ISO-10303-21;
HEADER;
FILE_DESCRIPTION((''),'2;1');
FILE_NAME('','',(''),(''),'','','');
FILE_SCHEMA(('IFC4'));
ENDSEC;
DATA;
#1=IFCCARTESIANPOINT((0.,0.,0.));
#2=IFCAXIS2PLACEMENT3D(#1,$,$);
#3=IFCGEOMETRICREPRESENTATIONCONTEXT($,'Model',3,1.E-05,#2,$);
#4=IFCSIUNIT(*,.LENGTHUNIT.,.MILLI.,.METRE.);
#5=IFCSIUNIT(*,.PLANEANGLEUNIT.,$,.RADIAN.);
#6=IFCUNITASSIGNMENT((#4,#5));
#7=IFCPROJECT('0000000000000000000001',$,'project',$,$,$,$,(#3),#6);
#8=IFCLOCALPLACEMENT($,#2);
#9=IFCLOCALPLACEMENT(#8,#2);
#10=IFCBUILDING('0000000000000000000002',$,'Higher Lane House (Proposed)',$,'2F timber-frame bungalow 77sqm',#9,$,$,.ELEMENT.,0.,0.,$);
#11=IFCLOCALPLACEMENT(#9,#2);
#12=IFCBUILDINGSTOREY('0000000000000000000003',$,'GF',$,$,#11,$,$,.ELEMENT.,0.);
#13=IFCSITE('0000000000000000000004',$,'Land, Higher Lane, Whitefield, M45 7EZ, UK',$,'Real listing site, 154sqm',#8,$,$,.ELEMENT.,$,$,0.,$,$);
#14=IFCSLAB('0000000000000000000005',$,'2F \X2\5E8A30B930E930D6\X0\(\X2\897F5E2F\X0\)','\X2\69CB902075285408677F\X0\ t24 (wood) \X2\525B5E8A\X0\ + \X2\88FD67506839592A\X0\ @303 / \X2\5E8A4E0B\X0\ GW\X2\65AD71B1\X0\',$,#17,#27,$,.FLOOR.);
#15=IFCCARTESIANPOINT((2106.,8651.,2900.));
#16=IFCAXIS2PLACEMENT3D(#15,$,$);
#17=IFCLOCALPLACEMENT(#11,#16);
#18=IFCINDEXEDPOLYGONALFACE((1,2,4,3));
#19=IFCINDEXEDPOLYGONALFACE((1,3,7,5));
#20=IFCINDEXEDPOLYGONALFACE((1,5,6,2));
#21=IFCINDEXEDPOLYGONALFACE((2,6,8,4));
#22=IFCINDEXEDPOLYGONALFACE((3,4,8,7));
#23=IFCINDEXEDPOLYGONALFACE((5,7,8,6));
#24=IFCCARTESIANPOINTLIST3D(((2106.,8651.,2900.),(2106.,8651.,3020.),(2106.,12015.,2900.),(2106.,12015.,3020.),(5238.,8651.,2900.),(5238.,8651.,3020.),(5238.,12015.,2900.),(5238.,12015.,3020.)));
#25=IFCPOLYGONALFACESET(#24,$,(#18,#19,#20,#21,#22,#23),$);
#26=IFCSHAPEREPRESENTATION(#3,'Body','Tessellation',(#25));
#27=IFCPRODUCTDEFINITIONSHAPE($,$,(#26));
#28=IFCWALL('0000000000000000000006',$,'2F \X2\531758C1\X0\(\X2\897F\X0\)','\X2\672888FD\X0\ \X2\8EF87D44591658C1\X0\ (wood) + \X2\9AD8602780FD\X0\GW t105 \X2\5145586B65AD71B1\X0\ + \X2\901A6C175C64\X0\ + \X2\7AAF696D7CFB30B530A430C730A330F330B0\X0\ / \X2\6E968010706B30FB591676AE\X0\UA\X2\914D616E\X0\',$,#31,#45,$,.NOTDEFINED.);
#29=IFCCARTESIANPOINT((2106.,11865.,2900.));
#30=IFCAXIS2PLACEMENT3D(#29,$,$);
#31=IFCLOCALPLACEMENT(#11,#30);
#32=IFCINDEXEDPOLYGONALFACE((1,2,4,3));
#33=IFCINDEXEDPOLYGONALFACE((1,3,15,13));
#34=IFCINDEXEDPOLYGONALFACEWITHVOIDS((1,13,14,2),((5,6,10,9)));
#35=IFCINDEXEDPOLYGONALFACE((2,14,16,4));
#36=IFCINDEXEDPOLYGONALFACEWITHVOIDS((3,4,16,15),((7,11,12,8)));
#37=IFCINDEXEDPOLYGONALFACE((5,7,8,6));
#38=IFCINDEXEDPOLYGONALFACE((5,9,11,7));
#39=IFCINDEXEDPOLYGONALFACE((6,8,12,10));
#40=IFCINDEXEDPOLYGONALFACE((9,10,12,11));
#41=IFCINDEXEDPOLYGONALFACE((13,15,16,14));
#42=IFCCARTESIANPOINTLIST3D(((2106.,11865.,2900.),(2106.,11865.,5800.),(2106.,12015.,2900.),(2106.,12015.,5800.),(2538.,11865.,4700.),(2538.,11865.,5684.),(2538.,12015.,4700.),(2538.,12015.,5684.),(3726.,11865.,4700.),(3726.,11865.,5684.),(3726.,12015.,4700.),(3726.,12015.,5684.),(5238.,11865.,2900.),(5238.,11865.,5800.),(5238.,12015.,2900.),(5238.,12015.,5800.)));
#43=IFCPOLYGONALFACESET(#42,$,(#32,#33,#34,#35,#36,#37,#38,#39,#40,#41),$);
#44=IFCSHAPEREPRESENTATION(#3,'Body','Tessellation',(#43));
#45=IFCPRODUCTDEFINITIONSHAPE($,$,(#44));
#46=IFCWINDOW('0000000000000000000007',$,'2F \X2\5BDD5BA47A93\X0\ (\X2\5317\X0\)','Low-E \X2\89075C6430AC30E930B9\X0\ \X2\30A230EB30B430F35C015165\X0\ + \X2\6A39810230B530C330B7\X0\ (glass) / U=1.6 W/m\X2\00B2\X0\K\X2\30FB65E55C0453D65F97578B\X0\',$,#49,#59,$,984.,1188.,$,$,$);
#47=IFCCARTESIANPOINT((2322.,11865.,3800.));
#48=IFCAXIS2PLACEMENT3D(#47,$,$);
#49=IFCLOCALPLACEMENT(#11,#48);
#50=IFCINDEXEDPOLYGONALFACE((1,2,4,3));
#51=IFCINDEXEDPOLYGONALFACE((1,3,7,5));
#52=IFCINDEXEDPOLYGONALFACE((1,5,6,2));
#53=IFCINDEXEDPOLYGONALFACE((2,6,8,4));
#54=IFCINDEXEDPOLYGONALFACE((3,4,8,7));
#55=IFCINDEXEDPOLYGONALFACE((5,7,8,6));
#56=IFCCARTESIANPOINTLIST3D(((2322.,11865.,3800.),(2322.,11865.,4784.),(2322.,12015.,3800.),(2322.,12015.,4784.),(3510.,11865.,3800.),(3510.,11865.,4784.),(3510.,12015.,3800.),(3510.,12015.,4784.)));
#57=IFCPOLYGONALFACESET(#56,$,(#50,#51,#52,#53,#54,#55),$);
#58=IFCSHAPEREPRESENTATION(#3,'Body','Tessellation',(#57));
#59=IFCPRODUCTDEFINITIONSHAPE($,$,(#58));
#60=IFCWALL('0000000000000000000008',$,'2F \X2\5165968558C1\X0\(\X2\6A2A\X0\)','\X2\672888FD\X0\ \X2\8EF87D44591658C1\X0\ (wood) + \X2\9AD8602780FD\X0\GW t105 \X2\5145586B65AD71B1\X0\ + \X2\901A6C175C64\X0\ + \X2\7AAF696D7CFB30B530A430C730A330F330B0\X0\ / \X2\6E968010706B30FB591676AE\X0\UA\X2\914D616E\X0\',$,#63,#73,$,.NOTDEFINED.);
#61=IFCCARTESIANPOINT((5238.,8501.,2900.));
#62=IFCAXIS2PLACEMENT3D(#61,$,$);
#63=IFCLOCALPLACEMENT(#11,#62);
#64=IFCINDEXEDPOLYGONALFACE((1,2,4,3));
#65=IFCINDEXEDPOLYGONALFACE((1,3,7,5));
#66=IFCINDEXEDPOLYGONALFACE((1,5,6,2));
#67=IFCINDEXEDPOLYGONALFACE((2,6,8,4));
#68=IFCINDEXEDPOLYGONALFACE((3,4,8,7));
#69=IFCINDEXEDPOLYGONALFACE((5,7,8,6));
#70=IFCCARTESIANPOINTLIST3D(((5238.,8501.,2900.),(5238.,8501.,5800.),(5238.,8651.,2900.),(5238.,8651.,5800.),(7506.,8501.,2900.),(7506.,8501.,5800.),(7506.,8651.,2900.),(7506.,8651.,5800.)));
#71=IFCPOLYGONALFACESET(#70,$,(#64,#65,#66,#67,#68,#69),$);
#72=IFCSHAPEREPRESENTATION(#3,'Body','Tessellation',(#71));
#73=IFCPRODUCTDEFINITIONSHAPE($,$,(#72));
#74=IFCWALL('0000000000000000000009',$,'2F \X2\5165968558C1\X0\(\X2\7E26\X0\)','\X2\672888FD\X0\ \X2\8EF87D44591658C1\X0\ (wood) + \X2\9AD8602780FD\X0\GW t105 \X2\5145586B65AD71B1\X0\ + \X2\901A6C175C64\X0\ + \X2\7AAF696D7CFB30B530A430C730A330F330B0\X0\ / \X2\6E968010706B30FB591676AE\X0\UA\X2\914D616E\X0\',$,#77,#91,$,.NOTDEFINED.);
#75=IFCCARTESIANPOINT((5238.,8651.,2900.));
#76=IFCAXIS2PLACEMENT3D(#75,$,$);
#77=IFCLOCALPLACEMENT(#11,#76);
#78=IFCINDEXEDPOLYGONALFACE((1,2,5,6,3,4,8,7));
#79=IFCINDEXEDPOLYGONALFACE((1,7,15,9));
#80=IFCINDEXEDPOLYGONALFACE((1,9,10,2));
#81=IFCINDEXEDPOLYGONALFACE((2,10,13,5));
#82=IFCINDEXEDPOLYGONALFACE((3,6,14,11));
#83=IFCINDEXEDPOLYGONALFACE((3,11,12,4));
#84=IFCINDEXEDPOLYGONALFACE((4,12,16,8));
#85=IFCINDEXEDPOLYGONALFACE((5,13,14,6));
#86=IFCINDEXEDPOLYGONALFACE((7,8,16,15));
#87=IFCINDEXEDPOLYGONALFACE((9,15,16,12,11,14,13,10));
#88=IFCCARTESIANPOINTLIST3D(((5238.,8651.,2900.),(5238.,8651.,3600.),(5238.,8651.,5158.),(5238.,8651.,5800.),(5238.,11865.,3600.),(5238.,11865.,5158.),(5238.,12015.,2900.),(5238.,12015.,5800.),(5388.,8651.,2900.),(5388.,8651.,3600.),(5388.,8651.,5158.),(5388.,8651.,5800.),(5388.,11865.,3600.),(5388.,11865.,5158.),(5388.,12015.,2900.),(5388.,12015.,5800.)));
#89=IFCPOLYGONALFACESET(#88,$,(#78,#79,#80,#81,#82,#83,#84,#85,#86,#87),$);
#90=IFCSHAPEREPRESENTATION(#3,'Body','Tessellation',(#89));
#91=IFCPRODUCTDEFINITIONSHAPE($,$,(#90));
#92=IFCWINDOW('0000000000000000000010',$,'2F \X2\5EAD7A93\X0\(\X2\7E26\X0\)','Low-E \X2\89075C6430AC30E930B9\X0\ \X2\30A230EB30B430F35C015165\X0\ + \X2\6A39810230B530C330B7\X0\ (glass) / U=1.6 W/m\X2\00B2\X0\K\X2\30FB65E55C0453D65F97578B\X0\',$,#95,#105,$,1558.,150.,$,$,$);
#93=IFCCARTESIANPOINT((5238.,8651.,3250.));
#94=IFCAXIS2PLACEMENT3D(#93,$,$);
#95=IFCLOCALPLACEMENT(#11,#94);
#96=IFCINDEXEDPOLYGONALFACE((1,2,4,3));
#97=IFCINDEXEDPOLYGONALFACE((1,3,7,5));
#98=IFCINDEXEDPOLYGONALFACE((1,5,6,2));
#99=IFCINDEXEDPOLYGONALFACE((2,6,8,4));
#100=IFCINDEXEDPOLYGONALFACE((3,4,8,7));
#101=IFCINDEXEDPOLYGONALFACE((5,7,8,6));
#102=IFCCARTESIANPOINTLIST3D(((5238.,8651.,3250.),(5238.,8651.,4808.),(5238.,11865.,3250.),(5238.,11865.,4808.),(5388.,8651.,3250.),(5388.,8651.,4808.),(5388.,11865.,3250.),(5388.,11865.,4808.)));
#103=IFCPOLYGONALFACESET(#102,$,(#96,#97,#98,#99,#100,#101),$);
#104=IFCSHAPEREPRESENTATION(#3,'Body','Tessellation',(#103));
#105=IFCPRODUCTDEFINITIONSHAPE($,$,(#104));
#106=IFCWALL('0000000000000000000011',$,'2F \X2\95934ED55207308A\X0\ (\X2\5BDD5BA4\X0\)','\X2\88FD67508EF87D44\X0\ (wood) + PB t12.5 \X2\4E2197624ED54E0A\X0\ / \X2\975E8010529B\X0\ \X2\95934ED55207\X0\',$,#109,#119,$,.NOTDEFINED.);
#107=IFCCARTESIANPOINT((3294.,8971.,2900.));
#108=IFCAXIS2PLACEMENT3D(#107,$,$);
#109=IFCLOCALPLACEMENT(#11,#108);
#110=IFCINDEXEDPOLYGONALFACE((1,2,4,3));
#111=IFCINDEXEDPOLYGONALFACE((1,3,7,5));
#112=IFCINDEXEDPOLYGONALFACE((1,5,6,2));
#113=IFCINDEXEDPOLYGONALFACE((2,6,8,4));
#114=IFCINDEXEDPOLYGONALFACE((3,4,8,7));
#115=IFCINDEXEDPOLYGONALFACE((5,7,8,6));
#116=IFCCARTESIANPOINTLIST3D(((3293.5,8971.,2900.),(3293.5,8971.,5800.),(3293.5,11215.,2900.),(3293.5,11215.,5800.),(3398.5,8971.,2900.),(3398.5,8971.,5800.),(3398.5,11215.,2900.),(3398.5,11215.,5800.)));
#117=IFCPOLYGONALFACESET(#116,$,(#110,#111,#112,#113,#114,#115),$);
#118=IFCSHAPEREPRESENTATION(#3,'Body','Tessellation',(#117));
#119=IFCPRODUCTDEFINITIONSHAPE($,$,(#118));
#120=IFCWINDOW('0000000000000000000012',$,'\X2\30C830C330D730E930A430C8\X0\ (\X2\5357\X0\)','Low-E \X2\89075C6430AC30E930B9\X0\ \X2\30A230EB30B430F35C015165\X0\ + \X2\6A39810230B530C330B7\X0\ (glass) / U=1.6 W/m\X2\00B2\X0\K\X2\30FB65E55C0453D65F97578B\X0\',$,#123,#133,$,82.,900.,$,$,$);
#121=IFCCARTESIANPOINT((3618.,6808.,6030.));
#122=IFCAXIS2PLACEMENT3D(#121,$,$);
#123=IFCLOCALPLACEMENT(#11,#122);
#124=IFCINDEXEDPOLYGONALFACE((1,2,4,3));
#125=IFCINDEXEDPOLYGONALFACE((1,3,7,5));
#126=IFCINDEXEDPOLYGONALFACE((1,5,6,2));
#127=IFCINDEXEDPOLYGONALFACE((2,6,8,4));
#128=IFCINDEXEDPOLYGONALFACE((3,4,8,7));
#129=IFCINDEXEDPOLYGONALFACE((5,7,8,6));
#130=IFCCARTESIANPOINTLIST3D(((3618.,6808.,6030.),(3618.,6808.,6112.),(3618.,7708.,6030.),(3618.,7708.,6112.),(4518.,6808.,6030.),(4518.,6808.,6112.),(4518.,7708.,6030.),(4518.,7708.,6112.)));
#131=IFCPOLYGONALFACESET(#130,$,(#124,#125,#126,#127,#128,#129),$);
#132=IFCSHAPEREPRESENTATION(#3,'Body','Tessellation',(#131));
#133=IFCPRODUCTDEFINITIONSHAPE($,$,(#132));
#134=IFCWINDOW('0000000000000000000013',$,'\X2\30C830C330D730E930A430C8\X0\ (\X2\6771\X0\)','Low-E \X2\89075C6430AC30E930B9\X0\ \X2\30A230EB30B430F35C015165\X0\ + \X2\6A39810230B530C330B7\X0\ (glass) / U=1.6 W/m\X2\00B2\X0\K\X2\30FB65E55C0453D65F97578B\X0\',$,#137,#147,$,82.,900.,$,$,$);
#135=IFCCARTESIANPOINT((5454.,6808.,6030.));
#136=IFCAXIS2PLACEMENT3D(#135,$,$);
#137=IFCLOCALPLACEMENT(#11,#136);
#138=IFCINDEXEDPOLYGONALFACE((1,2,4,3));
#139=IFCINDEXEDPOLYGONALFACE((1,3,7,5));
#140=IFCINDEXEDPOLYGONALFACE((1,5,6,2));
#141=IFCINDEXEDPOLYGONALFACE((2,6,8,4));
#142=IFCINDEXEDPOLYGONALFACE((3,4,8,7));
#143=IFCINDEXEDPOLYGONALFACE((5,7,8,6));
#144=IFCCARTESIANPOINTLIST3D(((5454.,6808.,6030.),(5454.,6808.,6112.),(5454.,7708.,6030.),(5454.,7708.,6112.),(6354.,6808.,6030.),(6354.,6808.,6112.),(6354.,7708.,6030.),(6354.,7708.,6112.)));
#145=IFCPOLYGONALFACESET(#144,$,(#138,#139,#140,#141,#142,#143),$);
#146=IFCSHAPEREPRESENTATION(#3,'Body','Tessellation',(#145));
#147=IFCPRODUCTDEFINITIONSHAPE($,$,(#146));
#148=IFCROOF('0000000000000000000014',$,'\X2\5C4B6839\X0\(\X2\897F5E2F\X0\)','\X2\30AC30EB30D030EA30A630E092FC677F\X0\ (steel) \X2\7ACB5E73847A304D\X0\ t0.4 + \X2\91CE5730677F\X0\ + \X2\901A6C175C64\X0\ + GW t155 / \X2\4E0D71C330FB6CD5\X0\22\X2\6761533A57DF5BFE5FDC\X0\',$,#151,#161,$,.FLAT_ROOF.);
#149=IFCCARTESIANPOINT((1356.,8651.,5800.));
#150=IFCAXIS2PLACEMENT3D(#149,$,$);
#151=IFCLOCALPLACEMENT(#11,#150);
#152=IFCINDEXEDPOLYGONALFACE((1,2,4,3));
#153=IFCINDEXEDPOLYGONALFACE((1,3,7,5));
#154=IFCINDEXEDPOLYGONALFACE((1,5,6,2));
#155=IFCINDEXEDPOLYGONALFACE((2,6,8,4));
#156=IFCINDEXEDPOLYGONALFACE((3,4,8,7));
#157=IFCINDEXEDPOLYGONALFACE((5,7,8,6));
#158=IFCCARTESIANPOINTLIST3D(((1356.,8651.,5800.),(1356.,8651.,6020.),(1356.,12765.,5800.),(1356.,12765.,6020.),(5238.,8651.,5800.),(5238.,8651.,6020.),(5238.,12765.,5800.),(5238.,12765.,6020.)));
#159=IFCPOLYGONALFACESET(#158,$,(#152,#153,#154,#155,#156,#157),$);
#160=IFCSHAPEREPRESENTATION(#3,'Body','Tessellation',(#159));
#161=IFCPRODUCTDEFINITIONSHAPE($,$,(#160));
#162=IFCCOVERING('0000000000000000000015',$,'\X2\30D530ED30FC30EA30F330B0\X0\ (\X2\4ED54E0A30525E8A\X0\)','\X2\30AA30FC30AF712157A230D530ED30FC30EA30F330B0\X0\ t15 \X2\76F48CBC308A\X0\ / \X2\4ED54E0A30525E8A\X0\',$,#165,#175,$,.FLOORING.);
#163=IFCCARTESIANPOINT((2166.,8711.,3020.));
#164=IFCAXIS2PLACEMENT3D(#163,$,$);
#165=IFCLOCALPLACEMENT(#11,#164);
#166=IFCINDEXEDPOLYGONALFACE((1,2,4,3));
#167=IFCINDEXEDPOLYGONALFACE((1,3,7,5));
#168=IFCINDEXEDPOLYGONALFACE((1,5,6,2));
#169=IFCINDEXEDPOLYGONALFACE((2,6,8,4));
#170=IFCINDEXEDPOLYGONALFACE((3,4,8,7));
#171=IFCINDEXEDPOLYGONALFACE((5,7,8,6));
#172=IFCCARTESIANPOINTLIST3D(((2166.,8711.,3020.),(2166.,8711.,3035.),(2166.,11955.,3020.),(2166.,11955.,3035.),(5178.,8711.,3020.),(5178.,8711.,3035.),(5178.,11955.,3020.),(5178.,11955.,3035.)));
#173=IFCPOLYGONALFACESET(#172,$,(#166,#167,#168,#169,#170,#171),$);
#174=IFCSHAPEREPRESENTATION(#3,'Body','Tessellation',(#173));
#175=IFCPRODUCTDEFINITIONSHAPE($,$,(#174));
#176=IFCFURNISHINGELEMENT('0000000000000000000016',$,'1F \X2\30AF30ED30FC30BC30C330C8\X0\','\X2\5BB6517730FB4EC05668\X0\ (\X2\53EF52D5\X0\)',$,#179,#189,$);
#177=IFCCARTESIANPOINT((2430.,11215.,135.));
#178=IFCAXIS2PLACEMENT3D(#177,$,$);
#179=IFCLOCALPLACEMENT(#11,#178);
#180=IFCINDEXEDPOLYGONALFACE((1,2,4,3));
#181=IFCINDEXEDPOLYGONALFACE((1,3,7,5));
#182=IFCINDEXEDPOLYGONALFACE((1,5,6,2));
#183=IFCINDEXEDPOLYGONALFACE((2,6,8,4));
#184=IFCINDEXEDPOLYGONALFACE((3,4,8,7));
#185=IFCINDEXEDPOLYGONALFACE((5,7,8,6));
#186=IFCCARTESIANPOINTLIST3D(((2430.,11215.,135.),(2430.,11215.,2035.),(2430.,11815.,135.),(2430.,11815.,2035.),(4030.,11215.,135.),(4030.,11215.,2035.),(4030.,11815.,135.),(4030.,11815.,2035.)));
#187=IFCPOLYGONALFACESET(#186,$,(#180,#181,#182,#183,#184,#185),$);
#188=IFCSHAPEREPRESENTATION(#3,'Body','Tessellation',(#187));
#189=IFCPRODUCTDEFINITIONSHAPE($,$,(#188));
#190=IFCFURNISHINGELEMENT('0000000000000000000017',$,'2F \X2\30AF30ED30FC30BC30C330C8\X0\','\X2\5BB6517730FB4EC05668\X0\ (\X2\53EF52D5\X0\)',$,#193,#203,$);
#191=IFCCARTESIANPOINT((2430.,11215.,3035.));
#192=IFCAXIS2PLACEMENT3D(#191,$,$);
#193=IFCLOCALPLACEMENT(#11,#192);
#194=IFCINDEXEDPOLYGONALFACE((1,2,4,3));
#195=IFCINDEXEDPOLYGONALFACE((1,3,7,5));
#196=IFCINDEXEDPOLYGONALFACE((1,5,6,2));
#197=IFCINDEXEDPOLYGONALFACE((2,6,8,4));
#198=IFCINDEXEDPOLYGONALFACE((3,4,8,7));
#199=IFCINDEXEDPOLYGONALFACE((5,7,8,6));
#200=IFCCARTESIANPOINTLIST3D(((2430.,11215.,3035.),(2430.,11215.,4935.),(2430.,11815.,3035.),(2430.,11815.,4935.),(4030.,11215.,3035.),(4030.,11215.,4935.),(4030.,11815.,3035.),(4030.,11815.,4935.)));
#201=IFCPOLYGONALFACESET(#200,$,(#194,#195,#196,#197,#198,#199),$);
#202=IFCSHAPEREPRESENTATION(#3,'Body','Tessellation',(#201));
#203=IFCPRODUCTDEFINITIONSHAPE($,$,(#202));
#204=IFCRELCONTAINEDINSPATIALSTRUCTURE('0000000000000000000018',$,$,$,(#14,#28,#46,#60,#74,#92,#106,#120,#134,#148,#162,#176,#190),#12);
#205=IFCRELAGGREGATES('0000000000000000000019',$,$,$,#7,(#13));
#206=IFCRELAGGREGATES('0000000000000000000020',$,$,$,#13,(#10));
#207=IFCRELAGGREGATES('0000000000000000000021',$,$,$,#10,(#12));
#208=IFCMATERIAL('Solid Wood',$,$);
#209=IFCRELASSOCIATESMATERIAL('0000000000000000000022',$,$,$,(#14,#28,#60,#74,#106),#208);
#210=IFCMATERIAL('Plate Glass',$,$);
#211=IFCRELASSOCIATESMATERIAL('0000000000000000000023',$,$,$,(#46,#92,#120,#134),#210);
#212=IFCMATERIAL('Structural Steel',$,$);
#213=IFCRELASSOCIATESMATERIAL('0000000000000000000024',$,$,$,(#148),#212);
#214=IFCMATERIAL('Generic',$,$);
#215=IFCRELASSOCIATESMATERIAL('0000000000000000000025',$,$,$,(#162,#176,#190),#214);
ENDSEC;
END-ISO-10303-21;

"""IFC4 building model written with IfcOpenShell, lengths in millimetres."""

from ifc_helpers import new_model, si_unit, frame, frame_2d, origin, place, context, project, spatial, rectangle, extrude, material, element, fill, save


model = new_model("IFC4")

# Units and contexts
model_context = context("Model", 3, precision=1e-05, world=origin())
ifc_project = project(units=[si_unit("LENGTHUNIT", "METRE", prefix="MILLI"), si_unit("PLANEANGLEUNIT", "RADIAN")], contexts=[model_context])

# Site, building, storey
site_placement = place(None, origin())
site = spatial("IfcSite", under=ifc_project, at=site_placement, Name="Land, Higher Lane, Whitefield, M45 7EZ, UK", ObjectType="Real listing site, 154sqm", CompositionType="ELEMENT", RefElevation=0.0)
building_placement = place(site_placement, origin())
building = spatial("IfcBuilding", under=site, at=building_placement, Name="Higher Lane House (Proposed)", ObjectType="2F timber-frame bungalow 77sqm", CompositionType="ELEMENT", ElevationOfRefHeight=0.0, ElevationOfTerrain=0.0)
storey_placement = place(building_placement, origin())
storey = spatial("IfcBuildingStorey", under=building, at=storey_placement, Name="GF", CompositionType="ELEMENT", Elevation=0.0)

# Slab
ifc_material_1 = material(Name="Solid Wood")
slab_placement = place(storey_placement, frame((2106.0, 8651.0, 2900.0)))
element("IfcSlab", 1, at=slab_placement, inside=storey, material=ifc_material_1, Name="2F 床スラブ(西帯)", Description="構造用合板 t24 (wood) 剛床 + 製材根太 @303 / 床下 GW断熱", PredefinedType="FLOOR", context=model_context, shape_type="SweptSolid", body=[
    extrude(rectangle(XDim=3132.0, YDim=3364.0, at=frame_2d((1566.0, 1682.0))), frame((2106.0, 8651.0, 2900.0)), (0.0, 0.0, 1.0), 120.0),
])

# Wall, opening, window
wall_1_placement = place(storey_placement, frame((2106.0, 11865.0, 2900.0)))
wall_1 = element("IfcWall", 2, at=wall_1_placement, inside=storey, material=ifc_material_1, Name="2F 北壁(西)", Description="木製 軸組外壁 (wood) + 高性能GW t105 充填断熱 + 通気層 + 窯業系サイディング / 準耐火・外皮UA配慮", PredefinedType="NOTDEFINED", context=model_context, shape_type="SweptSolid", body=[
    extrude(rectangle(XDim=3132.0, YDim=150.0, at=frame_2d((1566.0, 75.0))), frame((2106.0, 11865.0, 2900.0)), (0.0, 0.0, 1.0), 2900.0),
])
opening_1_placement = place(storey_placement, frame((2322.0, 11865.0, 3800.0)))
opening_1 = element("IfcOpeningElement", 3, at=opening_1_placement, cuts=wall_1, PredefinedType="NOTDEFINED", context=model_context, shape_type="SweptSolid", body=[
    extrude(rectangle(XDim=1188.0, YDim=150.0, at=frame_2d((594.0, 75.0))), frame((2322.0, 11865.0, 3800.0)), (0.0, 0.0, 1.0), 984.0),
])
ifc_material_2 = material(Name="Plate Glass")
window_1_placement = place(storey_placement, frame((2322.0, 11865.0, 3800.0)))
window_1 = element("IfcWindow", 4, at=window_1_placement, inside=storey, material=ifc_material_2, Name="2F 寝室窓 (北)", Description="Low-E 複層ガラス アルゴン封入 + 樹脂サッシ (glass) / U=1.6 W/m²K・日射取得型", OverallHeight=984.0, OverallWidth=1188.0, context=model_context, shape_type="SweptSolid", body=[
    extrude(rectangle(XDim=1188.0, YDim=150.0, at=frame_2d((594.0, 75.0))), frame((2322.0, 11865.0, 3800.0)), (0.0, 0.0, 1.0), 984.0),
])
fill(opening_1, window_1)

# Wall
wall_2_placement = place(storey_placement, frame((5238.0, 8501.0, 2900.0)))
element("IfcWall", 5, at=wall_2_placement, inside=storey, material=ifc_material_1, Name="2F 入隅壁(横)", Description="木製 軸組外壁 (wood) + 高性能GW t105 充填断熱 + 通気層 + 窯業系サイディング / 準耐火・外皮UA配慮", PredefinedType="NOTDEFINED", context=model_context, shape_type="SweptSolid", body=[
    extrude(rectangle(XDim=2268.0, YDim=150.0, at=frame_2d((1134.0, 75.0))), frame((5238.0, 8501.0, 2900.0)), (0.0, 0.0, 1.0), 2900.0),
])

# Wall, opening, window
wall_3_placement = place(storey_placement, frame((5238.0, 8651.0, 2900.0)))
wall_3 = element("IfcWall", 6, at=wall_3_placement, inside=storey, material=ifc_material_1, Name="2F 入隅壁(縦)", Description="木製 軸組外壁 (wood) + 高性能GW t105 充填断熱 + 通気層 + 窯業系サイディング / 準耐火・外皮UA配慮", PredefinedType="NOTDEFINED", context=model_context, shape_type="SweptSolid", body=[
    extrude(rectangle(XDim=150.0, YDim=3364.0, at=frame_2d((75.0, 1682.0))), frame((5238.0, 8651.0, 2900.0)), (0.0, 0.0, 1.0), 2900.0),
])
opening_2_placement = place(storey_placement, frame((5238.0, 8651.0, 3250.0)))
opening_2 = element("IfcOpeningElement", 7, at=opening_2_placement, cuts=wall_3, PredefinedType="NOTDEFINED", context=model_context, shape_type="SweptSolid", body=[
    extrude(rectangle(XDim=150.0, YDim=3214.0, at=frame_2d((75.0, 1607.0))), frame((5238.0, 8651.0, 3250.0)), (0.0, 0.0, 1.0), 1558.0),
])
window_2_placement = place(storey_placement, frame((5238.0, 8651.0, 3250.0)))
window_2 = element("IfcWindow", 8, at=window_2_placement, inside=storey, material=ifc_material_2, Name="2F 庭窓(縦)", Description="Low-E 複層ガラス アルゴン封入 + 樹脂サッシ (glass) / U=1.6 W/m²K・日射取得型", OverallHeight=1558.0, OverallWidth=150.0, context=model_context, shape_type="SweptSolid", body=[
    extrude(rectangle(XDim=150.0, YDim=3214.0, at=frame_2d((75.0, 1607.0))), frame((5238.0, 8651.0, 3250.0)), (0.0, 0.0, 1.0), 1558.0),
])
fill(opening_2, window_2)

# Wall
wall_4_placement = place(storey_placement, frame((3294.0, 8971.0, 2900.0)))
element("IfcWall", 9, at=wall_4_placement, inside=storey, material=ifc_material_1, Name="2F 間仕切り (寝室)", Description="製材軸組 (wood) + PB t12.5 両面仕上 / 非耐力 間仕切", PredefinedType="NOTDEFINED", context=model_context, shape_type="SweptSolid", body=[
    extrude(rectangle(XDim=105.0, YDim=2244.0, at=frame_2d((52.0, 1122.0))), frame((3294.0, 8971.0, 2900.0)), (0.0, 0.0, 1.0), 2900.0),
])

# Windows
window_3_placement = place(storey_placement, frame((3618.0, 6808.0, 6030.0)))
element("IfcWindow", 10, at=window_3_placement, inside=storey, material=ifc_material_2, Name="トップライト (南)", Description="Low-E 複層ガラス アルゴン封入 + 樹脂サッシ (glass) / U=1.6 W/m²K・日射取得型", OverallHeight=82.0, OverallWidth=900.0, context=model_context, shape_type="SweptSolid", body=[
    extrude(rectangle(XDim=900.0, YDim=900.0, at=frame_2d((450.0, 450.0))), frame((3618.0, 6808.0, 6030.0)), (0.0, 0.0, 1.0), 82.0),
])
window_4_placement = place(storey_placement, frame((5454.0, 6808.0, 6030.0)))
element("IfcWindow", 11, at=window_4_placement, inside=storey, material=ifc_material_2, Name="トップライト (東)", Description="Low-E 複層ガラス アルゴン封入 + 樹脂サッシ (glass) / U=1.6 W/m²K・日射取得型", OverallHeight=82.0, OverallWidth=900.0, context=model_context, shape_type="SweptSolid", body=[
    extrude(rectangle(XDim=900.0, YDim=900.0, at=frame_2d((450.0, 450.0))), frame((5454.0, 6808.0, 6030.0)), (0.0, 0.0, 1.0), 82.0),
])

# Roof
ifc_material_3 = material(Name="Structural Steel")
for number, where, name in (
    (12, (1356.0, 8651.0, 5800.0), "屋根(西帯)"),
):
    element("IfcRoof", number, at=place(storey_placement, frame(where)), inside=storey, material=ifc_material_3, Name=name, Description="ガルバリウム鋼板 (steel) 立平葺き t0.4 + 野地板 + 通気層 + GW t155 / 不燃・法22条区域対応", PredefinedType="FLAT_ROOF", context=model_context, shape_type="SweptSolid", body=[
        extrude(rectangle(XDim=3882.0, YDim=4114.0, at=frame_2d((1941.0, 2057.0))), frame((1356.0, 8651.0, 5800.0)), (0.0, 0.0, 1.0), 220.0),
    ])

# Covering
ifc_material_4 = material(Name="Generic")
covering_placement = place(storey_placement, frame((2166.0, 8711.0, 3020.0)))
element("IfcCovering", 13, at=covering_placement, inside=storey, material=ifc_material_4, Name="フローリング (仕上げ床)", Description="オーク無垢フローリング t15 直貼り / 仕上げ床", PredefinedType="FLOORING", context=model_context, shape_type="SweptSolid", body=[
    extrude(rectangle(XDim=3012.0, YDim=3244.0, at=frame_2d((1506.0, 1622.0))), frame((2166.0, 8711.0, 3020.0)), (0.0, 0.0, 1.0), 15.0),
])

# Furnishing elements
furnishing_1_placement = place(storey_placement, frame((2430.0, 11215.0, 135.0)))
element("IfcFurnishingElement", 14, at=furnishing_1_placement, inside=storey, material=ifc_material_4, Name="1F クローゼット", Description="家具・什器 (可動)", context=model_context, shape_type="SweptSolid", body=[
    extrude(rectangle(XDim=1600.0, YDim=600.0, at=frame_2d((800.0, 300.0))), frame((2430.0, 11215.0, 135.0)), (0.0, 0.0, 1.0), 1900.0),
])
furnishing_2_placement = place(storey_placement, frame((2430.0, 11215.0, 3035.0)))
element("IfcFurnishingElement", 15, at=furnishing_2_placement, inside=storey, material=ifc_material_4, Name="2F クローゼット", Description="家具・什器 (可動)", context=model_context, shape_type="SweptSolid", body=[
    extrude(rectangle(XDim=1600.0, YDim=600.0, at=frame_2d((800.0, 300.0))), frame((2430.0, 11215.0, 3035.0)), (0.0, 0.0, 1.0), 1900.0),
])

save(model, "model.ifc")
